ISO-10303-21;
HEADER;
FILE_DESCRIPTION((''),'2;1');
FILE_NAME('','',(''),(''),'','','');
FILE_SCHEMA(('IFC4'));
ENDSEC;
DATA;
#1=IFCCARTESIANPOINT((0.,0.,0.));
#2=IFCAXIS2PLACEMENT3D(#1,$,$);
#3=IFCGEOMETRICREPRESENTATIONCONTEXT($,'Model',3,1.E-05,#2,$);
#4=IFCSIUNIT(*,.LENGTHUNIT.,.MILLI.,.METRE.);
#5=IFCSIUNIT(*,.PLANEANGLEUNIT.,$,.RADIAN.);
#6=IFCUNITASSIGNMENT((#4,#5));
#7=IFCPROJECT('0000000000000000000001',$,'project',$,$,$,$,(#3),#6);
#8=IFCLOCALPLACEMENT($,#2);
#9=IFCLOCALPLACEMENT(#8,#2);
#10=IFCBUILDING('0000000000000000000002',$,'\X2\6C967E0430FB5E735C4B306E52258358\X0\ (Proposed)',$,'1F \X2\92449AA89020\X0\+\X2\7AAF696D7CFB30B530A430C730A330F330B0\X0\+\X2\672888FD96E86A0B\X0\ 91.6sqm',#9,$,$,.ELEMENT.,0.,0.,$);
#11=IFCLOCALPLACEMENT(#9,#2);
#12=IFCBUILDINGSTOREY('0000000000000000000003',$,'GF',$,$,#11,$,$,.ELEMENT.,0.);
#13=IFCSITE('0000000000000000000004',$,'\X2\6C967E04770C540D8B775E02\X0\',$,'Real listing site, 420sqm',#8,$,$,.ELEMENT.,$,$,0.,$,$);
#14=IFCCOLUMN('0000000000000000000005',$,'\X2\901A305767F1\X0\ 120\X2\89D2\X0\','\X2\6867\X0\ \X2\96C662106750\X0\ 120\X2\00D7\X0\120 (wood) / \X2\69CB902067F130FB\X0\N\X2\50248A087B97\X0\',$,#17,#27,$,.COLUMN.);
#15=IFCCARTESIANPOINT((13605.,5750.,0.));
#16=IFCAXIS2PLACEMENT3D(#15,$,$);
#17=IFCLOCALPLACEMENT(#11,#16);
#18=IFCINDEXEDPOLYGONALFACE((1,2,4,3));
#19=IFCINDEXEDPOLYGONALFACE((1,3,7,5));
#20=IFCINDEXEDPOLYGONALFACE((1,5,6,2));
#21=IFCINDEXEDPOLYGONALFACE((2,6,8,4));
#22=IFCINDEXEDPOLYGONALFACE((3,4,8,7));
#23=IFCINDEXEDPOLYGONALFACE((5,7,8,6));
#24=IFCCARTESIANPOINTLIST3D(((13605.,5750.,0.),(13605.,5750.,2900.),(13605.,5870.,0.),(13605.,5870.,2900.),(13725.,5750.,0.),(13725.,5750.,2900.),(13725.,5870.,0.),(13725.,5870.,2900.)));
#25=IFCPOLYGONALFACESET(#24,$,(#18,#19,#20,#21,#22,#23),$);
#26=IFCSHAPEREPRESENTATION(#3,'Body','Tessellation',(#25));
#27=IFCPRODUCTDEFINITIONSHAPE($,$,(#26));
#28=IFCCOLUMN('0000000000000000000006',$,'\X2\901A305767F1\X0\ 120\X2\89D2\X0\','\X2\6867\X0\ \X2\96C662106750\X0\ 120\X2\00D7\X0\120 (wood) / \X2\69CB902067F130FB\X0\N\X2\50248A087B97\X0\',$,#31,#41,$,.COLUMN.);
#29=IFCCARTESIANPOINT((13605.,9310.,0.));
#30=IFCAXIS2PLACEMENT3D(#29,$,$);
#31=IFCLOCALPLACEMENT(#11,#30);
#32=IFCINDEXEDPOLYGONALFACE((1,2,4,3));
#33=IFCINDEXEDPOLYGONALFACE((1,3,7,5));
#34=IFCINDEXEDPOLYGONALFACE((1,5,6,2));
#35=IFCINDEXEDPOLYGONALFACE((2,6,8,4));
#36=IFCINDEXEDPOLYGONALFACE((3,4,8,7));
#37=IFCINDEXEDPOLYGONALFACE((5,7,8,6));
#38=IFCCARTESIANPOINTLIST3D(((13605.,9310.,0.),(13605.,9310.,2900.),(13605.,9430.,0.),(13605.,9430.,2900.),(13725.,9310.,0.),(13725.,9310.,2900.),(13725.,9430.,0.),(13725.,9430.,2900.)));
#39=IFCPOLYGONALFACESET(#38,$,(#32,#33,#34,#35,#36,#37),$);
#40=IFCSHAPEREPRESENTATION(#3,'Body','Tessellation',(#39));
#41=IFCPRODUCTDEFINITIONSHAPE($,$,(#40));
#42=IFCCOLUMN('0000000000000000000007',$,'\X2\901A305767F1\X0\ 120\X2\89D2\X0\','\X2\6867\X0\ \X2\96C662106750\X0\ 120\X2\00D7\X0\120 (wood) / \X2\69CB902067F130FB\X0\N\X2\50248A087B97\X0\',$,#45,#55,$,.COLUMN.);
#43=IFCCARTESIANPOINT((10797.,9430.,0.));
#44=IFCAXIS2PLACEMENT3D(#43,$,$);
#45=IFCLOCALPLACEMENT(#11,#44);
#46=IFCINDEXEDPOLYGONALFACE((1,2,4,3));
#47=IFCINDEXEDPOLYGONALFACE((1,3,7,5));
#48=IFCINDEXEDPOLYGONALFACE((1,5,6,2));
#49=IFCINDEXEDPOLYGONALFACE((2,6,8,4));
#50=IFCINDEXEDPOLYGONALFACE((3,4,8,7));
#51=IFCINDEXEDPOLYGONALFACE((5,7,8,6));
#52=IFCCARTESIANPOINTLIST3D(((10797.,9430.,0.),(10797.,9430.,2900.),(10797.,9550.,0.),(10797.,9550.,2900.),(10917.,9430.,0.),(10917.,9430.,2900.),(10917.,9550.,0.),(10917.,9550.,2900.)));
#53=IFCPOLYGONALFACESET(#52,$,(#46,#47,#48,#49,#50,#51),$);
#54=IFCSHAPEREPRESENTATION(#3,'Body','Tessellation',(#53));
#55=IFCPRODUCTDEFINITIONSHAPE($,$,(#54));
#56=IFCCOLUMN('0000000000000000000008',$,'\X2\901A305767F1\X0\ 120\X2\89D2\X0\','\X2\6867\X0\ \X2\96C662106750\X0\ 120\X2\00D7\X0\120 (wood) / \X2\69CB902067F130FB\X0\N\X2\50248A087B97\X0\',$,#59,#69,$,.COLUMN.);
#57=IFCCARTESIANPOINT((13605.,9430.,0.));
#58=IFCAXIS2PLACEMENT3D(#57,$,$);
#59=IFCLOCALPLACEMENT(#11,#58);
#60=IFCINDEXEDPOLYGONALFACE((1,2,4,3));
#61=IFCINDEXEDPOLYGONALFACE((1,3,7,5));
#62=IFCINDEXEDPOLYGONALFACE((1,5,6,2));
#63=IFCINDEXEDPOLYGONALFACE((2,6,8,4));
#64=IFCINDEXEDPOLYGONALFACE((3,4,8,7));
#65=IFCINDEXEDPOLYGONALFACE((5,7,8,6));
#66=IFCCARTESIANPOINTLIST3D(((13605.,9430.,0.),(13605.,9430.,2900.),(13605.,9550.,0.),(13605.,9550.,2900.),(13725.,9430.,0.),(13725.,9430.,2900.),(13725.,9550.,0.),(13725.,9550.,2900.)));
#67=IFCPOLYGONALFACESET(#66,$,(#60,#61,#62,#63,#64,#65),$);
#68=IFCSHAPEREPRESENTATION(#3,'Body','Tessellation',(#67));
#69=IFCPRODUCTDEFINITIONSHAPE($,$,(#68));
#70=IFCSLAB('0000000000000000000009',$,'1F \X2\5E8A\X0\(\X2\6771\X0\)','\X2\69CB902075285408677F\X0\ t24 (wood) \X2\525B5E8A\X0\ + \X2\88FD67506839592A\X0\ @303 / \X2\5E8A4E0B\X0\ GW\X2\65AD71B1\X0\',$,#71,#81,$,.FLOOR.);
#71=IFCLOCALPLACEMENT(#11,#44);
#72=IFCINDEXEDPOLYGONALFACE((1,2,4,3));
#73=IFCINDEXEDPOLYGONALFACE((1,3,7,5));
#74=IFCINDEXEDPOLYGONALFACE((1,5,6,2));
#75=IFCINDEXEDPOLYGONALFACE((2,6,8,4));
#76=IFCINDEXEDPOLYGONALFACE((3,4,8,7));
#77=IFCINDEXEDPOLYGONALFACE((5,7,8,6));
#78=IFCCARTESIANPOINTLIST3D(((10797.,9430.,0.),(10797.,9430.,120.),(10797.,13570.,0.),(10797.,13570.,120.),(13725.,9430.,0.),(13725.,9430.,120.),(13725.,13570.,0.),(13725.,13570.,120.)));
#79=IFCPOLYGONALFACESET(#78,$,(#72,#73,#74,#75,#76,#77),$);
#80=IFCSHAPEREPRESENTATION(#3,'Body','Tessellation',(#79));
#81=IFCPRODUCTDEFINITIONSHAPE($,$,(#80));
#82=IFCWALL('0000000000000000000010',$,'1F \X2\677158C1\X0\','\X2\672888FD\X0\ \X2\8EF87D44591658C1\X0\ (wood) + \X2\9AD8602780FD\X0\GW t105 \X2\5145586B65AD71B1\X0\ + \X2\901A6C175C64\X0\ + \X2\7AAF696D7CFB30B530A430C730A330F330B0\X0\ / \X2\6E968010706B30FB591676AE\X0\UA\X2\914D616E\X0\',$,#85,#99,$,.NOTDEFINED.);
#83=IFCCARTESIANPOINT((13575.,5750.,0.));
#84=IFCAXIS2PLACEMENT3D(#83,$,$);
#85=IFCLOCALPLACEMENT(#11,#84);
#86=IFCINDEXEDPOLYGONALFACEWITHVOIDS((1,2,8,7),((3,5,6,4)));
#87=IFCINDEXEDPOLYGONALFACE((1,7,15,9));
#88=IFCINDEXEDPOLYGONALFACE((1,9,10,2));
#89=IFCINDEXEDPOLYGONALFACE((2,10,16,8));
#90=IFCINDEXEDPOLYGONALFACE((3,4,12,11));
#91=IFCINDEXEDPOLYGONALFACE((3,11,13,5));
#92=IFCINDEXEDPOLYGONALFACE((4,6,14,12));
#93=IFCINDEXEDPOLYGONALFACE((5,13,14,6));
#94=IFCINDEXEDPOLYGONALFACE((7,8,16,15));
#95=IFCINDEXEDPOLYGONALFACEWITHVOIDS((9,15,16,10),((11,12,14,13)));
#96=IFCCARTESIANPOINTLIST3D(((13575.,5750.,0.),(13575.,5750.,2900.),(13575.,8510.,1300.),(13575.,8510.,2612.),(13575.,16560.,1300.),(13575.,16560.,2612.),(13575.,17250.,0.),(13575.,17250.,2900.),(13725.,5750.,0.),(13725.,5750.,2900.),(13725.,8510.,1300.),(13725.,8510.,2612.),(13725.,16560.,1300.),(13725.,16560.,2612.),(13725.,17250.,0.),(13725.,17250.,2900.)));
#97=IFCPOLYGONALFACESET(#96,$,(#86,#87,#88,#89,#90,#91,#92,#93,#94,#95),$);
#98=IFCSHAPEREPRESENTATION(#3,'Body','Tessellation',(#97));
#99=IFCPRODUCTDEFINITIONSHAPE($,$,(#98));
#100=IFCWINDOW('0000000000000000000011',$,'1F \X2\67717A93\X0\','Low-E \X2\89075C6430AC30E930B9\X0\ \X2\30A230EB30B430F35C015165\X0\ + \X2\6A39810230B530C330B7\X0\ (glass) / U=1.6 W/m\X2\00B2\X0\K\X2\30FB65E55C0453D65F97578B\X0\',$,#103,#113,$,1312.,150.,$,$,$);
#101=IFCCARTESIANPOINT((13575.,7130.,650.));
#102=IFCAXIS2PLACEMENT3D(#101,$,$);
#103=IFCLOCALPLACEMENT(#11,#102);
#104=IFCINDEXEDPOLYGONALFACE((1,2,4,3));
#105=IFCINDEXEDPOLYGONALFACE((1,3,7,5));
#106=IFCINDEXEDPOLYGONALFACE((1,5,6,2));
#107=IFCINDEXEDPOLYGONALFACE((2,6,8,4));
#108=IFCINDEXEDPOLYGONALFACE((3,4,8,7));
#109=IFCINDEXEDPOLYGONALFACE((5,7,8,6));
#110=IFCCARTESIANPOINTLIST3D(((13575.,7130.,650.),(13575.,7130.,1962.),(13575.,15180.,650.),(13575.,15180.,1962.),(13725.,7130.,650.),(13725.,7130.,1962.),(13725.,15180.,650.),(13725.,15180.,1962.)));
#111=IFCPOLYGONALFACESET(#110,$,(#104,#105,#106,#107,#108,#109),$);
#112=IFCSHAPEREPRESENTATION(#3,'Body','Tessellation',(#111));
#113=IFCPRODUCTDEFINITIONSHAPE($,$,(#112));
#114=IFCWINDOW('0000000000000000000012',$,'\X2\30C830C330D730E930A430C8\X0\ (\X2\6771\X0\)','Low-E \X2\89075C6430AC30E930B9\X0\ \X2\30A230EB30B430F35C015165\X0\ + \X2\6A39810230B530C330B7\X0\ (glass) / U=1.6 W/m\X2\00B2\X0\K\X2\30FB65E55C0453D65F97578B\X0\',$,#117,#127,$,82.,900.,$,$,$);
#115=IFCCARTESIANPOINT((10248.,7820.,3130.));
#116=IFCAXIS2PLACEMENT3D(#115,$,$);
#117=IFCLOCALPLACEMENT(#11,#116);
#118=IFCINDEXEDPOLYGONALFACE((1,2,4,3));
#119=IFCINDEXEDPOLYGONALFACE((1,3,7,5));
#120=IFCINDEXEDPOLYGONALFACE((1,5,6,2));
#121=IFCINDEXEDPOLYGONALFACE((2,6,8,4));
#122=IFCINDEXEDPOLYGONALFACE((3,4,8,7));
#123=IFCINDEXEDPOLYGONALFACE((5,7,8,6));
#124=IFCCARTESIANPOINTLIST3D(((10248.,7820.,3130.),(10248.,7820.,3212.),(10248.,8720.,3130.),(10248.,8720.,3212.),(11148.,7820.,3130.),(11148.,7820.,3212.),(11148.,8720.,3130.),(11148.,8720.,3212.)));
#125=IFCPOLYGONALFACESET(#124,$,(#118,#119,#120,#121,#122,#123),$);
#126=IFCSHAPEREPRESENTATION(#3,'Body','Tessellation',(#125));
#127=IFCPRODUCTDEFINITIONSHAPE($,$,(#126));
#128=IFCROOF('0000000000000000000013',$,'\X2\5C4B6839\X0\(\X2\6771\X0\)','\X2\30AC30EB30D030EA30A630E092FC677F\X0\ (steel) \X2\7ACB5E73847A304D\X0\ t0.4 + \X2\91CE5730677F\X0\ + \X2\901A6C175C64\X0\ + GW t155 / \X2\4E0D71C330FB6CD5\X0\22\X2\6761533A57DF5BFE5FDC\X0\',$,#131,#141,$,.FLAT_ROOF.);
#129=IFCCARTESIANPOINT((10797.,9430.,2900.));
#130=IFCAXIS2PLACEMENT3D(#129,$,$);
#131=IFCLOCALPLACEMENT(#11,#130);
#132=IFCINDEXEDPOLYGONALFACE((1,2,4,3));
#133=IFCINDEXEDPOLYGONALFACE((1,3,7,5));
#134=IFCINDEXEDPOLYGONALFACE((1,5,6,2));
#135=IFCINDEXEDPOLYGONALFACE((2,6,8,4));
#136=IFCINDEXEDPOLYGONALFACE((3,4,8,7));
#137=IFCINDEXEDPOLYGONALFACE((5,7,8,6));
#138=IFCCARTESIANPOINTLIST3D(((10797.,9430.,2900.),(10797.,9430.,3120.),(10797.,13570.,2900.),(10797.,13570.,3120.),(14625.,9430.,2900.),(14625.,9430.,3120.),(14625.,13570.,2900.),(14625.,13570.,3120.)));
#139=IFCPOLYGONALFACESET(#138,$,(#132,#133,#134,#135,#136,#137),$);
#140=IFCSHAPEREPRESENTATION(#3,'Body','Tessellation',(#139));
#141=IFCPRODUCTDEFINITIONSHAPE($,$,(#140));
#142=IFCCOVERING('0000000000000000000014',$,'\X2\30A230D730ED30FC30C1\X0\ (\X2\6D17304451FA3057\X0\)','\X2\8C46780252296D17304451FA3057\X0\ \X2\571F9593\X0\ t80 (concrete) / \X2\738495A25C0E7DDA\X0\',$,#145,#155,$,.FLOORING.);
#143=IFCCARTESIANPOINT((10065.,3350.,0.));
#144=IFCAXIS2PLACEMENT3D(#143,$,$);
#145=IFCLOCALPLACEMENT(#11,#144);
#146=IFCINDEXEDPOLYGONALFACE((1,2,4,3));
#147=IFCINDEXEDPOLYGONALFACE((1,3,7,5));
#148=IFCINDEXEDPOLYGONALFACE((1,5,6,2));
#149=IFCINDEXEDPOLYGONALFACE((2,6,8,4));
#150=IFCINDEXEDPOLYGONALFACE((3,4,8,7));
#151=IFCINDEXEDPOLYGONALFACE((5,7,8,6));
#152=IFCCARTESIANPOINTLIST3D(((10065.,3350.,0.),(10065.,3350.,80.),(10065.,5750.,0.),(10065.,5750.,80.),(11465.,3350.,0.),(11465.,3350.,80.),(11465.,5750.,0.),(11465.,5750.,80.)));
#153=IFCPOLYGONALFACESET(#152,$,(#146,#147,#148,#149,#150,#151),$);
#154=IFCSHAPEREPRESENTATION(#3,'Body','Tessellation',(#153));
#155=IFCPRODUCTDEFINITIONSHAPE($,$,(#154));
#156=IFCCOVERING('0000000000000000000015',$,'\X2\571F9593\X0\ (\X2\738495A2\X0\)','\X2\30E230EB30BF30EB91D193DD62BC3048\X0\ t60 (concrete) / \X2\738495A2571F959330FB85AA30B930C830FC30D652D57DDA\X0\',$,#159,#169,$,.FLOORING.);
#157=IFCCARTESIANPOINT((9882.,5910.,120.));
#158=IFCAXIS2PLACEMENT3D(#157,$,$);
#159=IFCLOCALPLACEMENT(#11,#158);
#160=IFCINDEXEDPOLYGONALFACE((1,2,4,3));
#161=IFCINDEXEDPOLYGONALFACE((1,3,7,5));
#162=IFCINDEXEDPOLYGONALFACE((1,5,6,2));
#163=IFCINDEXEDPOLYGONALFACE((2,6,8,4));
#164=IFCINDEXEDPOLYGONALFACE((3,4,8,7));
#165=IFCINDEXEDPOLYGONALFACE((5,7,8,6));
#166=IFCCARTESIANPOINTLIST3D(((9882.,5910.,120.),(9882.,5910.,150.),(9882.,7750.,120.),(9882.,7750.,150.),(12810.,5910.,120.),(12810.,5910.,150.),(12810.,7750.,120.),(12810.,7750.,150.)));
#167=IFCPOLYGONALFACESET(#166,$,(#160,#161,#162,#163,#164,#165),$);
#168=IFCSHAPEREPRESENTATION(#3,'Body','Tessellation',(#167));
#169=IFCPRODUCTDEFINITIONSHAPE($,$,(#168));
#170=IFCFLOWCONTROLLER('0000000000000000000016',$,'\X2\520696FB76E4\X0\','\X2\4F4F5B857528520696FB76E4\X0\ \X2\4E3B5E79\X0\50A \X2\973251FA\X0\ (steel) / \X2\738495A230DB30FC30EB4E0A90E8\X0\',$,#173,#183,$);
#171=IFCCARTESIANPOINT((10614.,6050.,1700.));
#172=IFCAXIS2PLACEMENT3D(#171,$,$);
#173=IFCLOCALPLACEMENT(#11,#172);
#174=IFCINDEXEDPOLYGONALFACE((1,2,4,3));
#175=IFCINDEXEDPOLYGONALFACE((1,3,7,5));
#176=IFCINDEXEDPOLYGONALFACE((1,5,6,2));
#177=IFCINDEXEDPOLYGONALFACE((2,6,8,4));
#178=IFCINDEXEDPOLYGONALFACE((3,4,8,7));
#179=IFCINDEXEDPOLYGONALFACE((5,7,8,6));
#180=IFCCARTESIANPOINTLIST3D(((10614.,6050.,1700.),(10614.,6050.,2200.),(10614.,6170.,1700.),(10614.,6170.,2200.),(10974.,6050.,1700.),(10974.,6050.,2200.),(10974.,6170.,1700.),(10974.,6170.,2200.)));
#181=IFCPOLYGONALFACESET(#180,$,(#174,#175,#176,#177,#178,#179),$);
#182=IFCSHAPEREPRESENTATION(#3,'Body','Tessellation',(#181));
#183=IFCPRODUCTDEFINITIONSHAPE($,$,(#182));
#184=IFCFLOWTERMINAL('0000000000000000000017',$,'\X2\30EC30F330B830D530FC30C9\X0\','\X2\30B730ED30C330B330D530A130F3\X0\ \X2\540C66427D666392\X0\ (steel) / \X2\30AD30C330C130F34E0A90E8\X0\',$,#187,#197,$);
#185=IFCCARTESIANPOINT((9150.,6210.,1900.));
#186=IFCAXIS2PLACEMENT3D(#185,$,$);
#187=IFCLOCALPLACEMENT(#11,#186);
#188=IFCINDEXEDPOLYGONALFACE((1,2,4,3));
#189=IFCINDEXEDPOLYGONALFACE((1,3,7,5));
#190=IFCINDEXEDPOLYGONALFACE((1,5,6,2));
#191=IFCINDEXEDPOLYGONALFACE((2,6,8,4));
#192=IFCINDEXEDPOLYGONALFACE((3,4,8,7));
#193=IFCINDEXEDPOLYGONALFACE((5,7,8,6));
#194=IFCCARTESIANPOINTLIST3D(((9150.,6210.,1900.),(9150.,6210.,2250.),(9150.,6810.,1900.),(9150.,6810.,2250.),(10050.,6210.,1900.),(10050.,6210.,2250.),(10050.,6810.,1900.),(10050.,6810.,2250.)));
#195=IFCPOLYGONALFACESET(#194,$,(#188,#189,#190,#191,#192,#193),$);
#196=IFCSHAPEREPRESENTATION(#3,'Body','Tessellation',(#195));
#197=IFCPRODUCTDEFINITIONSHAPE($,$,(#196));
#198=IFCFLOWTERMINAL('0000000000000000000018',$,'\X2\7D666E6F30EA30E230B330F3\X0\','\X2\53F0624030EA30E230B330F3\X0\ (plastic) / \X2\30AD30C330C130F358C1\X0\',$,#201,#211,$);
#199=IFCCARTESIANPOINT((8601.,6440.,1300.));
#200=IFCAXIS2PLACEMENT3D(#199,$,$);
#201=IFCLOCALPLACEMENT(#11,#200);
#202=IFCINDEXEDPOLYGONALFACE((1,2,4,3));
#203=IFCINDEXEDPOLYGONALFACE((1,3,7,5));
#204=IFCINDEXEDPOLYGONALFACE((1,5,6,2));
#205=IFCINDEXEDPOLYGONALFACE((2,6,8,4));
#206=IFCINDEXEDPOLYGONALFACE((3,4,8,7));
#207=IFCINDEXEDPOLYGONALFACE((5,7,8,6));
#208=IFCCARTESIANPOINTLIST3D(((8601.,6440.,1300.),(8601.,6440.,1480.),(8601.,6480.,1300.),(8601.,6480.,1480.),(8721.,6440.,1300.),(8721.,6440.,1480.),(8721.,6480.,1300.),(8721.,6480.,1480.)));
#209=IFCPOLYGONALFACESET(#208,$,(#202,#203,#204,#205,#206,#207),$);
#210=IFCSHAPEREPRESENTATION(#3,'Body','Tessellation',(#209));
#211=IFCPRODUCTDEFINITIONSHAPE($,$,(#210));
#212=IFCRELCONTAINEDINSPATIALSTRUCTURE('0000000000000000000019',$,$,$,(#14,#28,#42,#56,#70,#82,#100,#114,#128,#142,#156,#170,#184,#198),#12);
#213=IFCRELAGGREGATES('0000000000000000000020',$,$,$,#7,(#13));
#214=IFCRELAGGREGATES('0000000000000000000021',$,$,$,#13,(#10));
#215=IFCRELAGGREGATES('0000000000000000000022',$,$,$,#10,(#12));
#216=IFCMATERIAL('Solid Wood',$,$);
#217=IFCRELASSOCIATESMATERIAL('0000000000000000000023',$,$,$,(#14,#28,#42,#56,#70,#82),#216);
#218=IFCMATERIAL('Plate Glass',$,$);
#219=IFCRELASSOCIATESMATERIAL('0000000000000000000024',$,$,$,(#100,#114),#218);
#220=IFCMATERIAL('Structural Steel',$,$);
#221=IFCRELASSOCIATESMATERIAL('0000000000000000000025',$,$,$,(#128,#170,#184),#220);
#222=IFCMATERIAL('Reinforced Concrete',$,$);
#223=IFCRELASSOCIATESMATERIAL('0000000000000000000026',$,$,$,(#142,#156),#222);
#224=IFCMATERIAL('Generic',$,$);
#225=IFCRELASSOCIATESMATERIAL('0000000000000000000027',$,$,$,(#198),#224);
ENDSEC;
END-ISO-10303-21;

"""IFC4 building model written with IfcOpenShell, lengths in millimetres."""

from ifc_helpers import new_model, si_unit, frame, frame_2d, origin, place, context, project, spatial, rectangle, extrude, material, element, fill, save


model = new_model("IFC4")

# Units and contexts
model_context = context("Model", 3, precision=1e-05, world=origin())
ifc_project = project(units=[si_unit("LENGTHUNIT", "METRE", prefix="MILLI"), si_unit("PLANEANGLEUNIT", "RADIAN")], contexts=[model_context])

# Site, building, storey
site_placement = place(None, origin())
site = spatial("IfcSite", under=ifc_project, at=site_placement, Name="沖縄県名護市", ObjectType="Real listing site, 420sqm", CompositionType="ELEMENT", RefElevation=0.0)
building_placement = place(site_placement, origin())
building = spatial("IfcBuilding", under=site, at=building_placement, Name="沖縄・平屋の別荘 (Proposed)", ObjectType="1F 鉄骨造+窯業系サイディング+木製雨樋 91.6sqm", CompositionType="ELEMENT", ElevationOfRefHeight=0.0, ElevationOfTerrain=0.0)
storey_placement = place(building_placement, origin())
storey = spatial("IfcBuildingStorey", under=building, at=storey_placement, Name="GF", CompositionType="ELEMENT", Elevation=0.0)

# Columns
ifc_material_1 = material(Name="Solid Wood")
column_1_placement = place(storey_placement, frame((13605.0, 5750.0, 0.0)))
element("IfcColumn", 1, at=column_1_placement, inside=storey, material=ifc_material_1, Name="通し柱 120角", Description="桧 集成材 120×120 (wood) / 構造柱・N値計算", PredefinedType="COLUMN", context=model_context, shape_type="SweptSolid", body=[
    extrude(rectangle(XDim=120.0, YDim=120.0, at=frame_2d((60.0, 60.0))), frame((13605.0, 5750.0, 0.0)), (0.0, 0.0, 1.0), 2900.0),
])
column_2_placement = place(storey_placement, frame((13605.0, 9310.0, 0.0)))
element("IfcColumn", 2, at=column_2_placement, inside=storey, material=ifc_material_1, Name="通し柱 120角", Description="桧 集成材 120×120 (wood) / 構造柱・N値計算", PredefinedType="COLUMN", context=model_context, shape_type="SweptSolid", body=[
    extrude(rectangle(XDim=120.0, YDim=120.0, at=frame_2d((60.0, 60.0))), frame((13605.0, 9310.0, 0.0)), (0.0, 0.0, 1.0), 2900.0),
])
column_3_placement = place(storey_placement, frame((10797.0, 9430.0, 0.0)))
element("IfcColumn", 3, at=column_3_placement, inside=storey, material=ifc_material_1, Name="通し柱 120角", Description="桧 集成材 120×120 (wood) / 構造柱・N値計算", PredefinedType="COLUMN", context=model_context, shape_type="SweptSolid", body=[
    extrude(rectangle(XDim=120.0, YDim=120.0, at=frame_2d((60.0, 60.0))), frame((10797.0, 9430.0, 0.0)), (0.0, 0.0, 1.0), 2900.0),
])
column_4_placement = place(storey_placement, frame((13605.0, 9430.0, 0.0)))
element("IfcColumn", 4, at=column_4_placement, inside=storey, material=ifc_material_1, Name="通し柱 120角", Description="桧 集成材 120×120 (wood) / 構造柱・N値計算", PredefinedType="COLUMN", context=model_context, shape_type="SweptSolid", body=[
    extrude(rectangle(XDim=120.0, YDim=120.0, at=frame_2d((60.0, 60.0))), frame((13605.0, 9430.0, 0.0)), (0.0, 0.0, 1.0), 2900.0),
])

# Slab
slab_placement = place(storey_placement, frame((10797.0, 9430.0, 0.0)))
element("IfcSlab", 5, at=slab_placement, inside=storey, material=ifc_material_1, Name="1F 床(東)", Description="構造用合板 t24 (wood) 剛床 + 製材根太 @303 / 床下 GW断熱", PredefinedType="FLOOR", context=model_context, shape_type="SweptSolid", body=[
    extrude(rectangle(XDim=2928.0, YDim=4140.0, at=frame_2d((1464.0, 2070.0))), frame((10797.0, 9430.0, 0.0)), (0.0, 0.0, 1.0), 120.0),
])

# Wall, opening, window
wall_1_placement = place(storey_placement, frame((13575.0, 5750.0, 0.0)))
wall_1 = element("IfcWall", 6, at=wall_1_placement, inside=storey, material=ifc_material_1, Name="1F 東壁", Description="木製 軸組外壁 (wood) + 高性能GW t105 充填断熱 + 通気層 + 窯業系サイディング / 準耐火・外皮UA配慮", PredefinedType="NOTDEFINED", context=model_context, shape_type="SweptSolid", body=[
    extrude(rectangle(XDim=150.0, YDim=11500.0, at=frame_2d((75.0, 5750.0))), frame((13575.0, 5750.0, 0.0)), (0.0, 0.0, 1.0), 2900.0),
])
opening_placement = place(storey_placement, frame((13575.0, 7130.0, 650.0)))
opening = element("IfcOpeningElement", 7, at=opening_placement, cuts=wall_1, PredefinedType="NOTDEFINED", context=model_context, shape_type="SweptSolid", body=[
    extrude(rectangle(XDim=150.0, YDim=8050.0, at=frame_2d((75.0, 4025.0))), frame((13575.0, 7130.0, 650.0)), (0.0, 0.0, 1.0), 1312.0),
])
ifc_material_2 = material(Name="Plate Glass")
window_1_placement = place(storey_placement, frame((13575.0, 7130.0, 650.0)))
window_1 = element("IfcWindow", 8, at=window_1_placement, inside=storey, material=ifc_material_2, Name="1F 東窓", Description="Low-E 複層ガラス アルゴン封入 + 樹脂サッシ (glass) / U=1.6 W/m²K・日射取得型", OverallHeight=1312.0, OverallWidth=150.0, context=model_context, shape_type="SweptSolid", body=[
    extrude(rectangle(XDim=150.0, YDim=8050.0, at=frame_2d((75.0, 4025.0))), frame((13575.0, 7130.0, 650.0)), (0.0, 0.0, 1.0), 1312.0),
])
fill(opening, window_1)

# Window
window_2_placement = place(storey_placement, frame((10248.0, 7820.0, 3130.0)))
element("IfcWindow", 9, at=window_2_placement, inside=storey, material=ifc_material_2, Name="トップライト (東)", Description="Low-E 複層ガラス アルゴン封入 + 樹脂サッシ (glass) / U=1.6 W/m²K・日射取得型", OverallHeight=82.0, OverallWidth=900.0, context=model_context, shape_type="SweptSolid", body=[
    extrude(rectangle(XDim=900.0, YDim=900.0, at=frame_2d((450.0, 450.0))), frame((10248.0, 7820.0, 3130.0)), (0.0, 0.0, 1.0), 82.0),
])

# Roof
ifc_material_3 = material(Name="Structural Steel")
roof_placement = place(storey_placement, frame((10797.0, 9430.0, 2900.0)))
element("IfcRoof", 10, at=roof_placement, inside=storey, material=ifc_material_3, Name="屋根(東)", Description="ガルバリウム鋼板 (steel) 立平葺き t0.4 + 野地板 + 通気層 + GW t155 / 不燃・法22条区域対応", PredefinedType="FLAT_ROOF", context=model_context, shape_type="SweptSolid", body=[
    extrude(rectangle(XDim=3828.0, YDim=4140.0, at=frame_2d((1914.0, 2070.0))), frame((10797.0, 9430.0, 2900.0)), (0.0, 0.0, 1.0), 220.0),
])

# Coverings
ifc_material_4 = material(Name="Reinforced Concrete")
covering_1_placement = place(storey_placement, frame((10065.0, 3350.0, 0.0)))
element("IfcCovering", 11, at=covering_1_placement, inside=storey, material=ifc_material_4, Name="アプローチ (洗い出し)", Description="豆砂利洗い出し 土間 t80 (concrete) / 玄関導線", PredefinedType="FLOORING", context=model_context, shape_type="SweptSolid", body=[
    extrude(rectangle(XDim=1400.0, YDim=2400.0, at=frame_2d((700.0, 1200.0))), frame((10065.0, 3350.0, 0.0)), (0.0, 0.0, 1.0), 80.0),
])
covering_2_placement = place(storey_placement, frame((9882.0, 5910.0, 120.0)))
element("IfcCovering", 12, at=covering_2_placement, inside=storey, material=ifc_material_4, Name="土間 (玄関)", Description="モルタル金鏝押え t60 (concrete) / 玄関土間・薪ストーブ動線", PredefinedType="FLOORING", context=model_context, shape_type="SweptSolid", body=[
    extrude(rectangle(XDim=2928.0, YDim=1840.0, at=frame_2d((1464.0, 920.0))), frame((9882.0, 5910.0, 120.0)), (0.0, 0.0, 1.0), 30.0),
])

# Flow controller
flow_controller_placement = place(storey_placement, frame((10614.0, 6050.0, 1700.0)))
element("IfcFlowController", 13, at=flow_controller_placement, inside=storey, material=ifc_material_3, Name="分電盤", Description="住宅用分電盤 主幹50A 露出 (steel) / 玄関ホール上部", context=model_context, shape_type="SweptSolid", body=[
    extrude(rectangle(XDim=360.0, YDim=120.0, at=frame_2d((180.0, 60.0))), frame((10614.0, 6050.0, 1700.0)), (0.0, 0.0, 1.0), 500.0),
])

# Flow terminals
flow_terminal_1_placement = place(storey_placement, frame((9150.0, 6210.0, 1900.0)))
element("IfcFlowTerminal", 14, at=flow_terminal_1_placement, inside=storey, material=ifc_material_3, Name="レンジフード", Description="シロッコファン 同時給排 (steel) / キッチン上部", context=model_context, shape_type="SweptSolid", body=[
    extrude(rectangle(XDim=900.0, YDim=600.0, at=frame_2d((450.0, 300.0))), frame((9150.0, 6210.0, 1900.0)), (0.0, 0.0, 1.0), 350.0),
])
ifc_material_5 = material(Name="Generic")
flow_terminal_2_placement = place(storey_placement, frame((8601.0, 6440.0, 1300.0)))
element("IfcFlowTerminal", 15, at=flow_terminal_2_placement, inside=storey, material=ifc_material_5, Name="給湯リモコン", Description="台所リモコン (plastic) / キッチン壁", context=model_context, shape_type="SweptSolid", body=[
    extrude(rectangle(XDim=120.0, YDim=40.0, at=frame_2d((60.0, 20.0))), frame((8601.0, 6440.0, 1300.0)), (0.0, 0.0, 1.0), 180.0),
])

save(model, "model.ifc")
